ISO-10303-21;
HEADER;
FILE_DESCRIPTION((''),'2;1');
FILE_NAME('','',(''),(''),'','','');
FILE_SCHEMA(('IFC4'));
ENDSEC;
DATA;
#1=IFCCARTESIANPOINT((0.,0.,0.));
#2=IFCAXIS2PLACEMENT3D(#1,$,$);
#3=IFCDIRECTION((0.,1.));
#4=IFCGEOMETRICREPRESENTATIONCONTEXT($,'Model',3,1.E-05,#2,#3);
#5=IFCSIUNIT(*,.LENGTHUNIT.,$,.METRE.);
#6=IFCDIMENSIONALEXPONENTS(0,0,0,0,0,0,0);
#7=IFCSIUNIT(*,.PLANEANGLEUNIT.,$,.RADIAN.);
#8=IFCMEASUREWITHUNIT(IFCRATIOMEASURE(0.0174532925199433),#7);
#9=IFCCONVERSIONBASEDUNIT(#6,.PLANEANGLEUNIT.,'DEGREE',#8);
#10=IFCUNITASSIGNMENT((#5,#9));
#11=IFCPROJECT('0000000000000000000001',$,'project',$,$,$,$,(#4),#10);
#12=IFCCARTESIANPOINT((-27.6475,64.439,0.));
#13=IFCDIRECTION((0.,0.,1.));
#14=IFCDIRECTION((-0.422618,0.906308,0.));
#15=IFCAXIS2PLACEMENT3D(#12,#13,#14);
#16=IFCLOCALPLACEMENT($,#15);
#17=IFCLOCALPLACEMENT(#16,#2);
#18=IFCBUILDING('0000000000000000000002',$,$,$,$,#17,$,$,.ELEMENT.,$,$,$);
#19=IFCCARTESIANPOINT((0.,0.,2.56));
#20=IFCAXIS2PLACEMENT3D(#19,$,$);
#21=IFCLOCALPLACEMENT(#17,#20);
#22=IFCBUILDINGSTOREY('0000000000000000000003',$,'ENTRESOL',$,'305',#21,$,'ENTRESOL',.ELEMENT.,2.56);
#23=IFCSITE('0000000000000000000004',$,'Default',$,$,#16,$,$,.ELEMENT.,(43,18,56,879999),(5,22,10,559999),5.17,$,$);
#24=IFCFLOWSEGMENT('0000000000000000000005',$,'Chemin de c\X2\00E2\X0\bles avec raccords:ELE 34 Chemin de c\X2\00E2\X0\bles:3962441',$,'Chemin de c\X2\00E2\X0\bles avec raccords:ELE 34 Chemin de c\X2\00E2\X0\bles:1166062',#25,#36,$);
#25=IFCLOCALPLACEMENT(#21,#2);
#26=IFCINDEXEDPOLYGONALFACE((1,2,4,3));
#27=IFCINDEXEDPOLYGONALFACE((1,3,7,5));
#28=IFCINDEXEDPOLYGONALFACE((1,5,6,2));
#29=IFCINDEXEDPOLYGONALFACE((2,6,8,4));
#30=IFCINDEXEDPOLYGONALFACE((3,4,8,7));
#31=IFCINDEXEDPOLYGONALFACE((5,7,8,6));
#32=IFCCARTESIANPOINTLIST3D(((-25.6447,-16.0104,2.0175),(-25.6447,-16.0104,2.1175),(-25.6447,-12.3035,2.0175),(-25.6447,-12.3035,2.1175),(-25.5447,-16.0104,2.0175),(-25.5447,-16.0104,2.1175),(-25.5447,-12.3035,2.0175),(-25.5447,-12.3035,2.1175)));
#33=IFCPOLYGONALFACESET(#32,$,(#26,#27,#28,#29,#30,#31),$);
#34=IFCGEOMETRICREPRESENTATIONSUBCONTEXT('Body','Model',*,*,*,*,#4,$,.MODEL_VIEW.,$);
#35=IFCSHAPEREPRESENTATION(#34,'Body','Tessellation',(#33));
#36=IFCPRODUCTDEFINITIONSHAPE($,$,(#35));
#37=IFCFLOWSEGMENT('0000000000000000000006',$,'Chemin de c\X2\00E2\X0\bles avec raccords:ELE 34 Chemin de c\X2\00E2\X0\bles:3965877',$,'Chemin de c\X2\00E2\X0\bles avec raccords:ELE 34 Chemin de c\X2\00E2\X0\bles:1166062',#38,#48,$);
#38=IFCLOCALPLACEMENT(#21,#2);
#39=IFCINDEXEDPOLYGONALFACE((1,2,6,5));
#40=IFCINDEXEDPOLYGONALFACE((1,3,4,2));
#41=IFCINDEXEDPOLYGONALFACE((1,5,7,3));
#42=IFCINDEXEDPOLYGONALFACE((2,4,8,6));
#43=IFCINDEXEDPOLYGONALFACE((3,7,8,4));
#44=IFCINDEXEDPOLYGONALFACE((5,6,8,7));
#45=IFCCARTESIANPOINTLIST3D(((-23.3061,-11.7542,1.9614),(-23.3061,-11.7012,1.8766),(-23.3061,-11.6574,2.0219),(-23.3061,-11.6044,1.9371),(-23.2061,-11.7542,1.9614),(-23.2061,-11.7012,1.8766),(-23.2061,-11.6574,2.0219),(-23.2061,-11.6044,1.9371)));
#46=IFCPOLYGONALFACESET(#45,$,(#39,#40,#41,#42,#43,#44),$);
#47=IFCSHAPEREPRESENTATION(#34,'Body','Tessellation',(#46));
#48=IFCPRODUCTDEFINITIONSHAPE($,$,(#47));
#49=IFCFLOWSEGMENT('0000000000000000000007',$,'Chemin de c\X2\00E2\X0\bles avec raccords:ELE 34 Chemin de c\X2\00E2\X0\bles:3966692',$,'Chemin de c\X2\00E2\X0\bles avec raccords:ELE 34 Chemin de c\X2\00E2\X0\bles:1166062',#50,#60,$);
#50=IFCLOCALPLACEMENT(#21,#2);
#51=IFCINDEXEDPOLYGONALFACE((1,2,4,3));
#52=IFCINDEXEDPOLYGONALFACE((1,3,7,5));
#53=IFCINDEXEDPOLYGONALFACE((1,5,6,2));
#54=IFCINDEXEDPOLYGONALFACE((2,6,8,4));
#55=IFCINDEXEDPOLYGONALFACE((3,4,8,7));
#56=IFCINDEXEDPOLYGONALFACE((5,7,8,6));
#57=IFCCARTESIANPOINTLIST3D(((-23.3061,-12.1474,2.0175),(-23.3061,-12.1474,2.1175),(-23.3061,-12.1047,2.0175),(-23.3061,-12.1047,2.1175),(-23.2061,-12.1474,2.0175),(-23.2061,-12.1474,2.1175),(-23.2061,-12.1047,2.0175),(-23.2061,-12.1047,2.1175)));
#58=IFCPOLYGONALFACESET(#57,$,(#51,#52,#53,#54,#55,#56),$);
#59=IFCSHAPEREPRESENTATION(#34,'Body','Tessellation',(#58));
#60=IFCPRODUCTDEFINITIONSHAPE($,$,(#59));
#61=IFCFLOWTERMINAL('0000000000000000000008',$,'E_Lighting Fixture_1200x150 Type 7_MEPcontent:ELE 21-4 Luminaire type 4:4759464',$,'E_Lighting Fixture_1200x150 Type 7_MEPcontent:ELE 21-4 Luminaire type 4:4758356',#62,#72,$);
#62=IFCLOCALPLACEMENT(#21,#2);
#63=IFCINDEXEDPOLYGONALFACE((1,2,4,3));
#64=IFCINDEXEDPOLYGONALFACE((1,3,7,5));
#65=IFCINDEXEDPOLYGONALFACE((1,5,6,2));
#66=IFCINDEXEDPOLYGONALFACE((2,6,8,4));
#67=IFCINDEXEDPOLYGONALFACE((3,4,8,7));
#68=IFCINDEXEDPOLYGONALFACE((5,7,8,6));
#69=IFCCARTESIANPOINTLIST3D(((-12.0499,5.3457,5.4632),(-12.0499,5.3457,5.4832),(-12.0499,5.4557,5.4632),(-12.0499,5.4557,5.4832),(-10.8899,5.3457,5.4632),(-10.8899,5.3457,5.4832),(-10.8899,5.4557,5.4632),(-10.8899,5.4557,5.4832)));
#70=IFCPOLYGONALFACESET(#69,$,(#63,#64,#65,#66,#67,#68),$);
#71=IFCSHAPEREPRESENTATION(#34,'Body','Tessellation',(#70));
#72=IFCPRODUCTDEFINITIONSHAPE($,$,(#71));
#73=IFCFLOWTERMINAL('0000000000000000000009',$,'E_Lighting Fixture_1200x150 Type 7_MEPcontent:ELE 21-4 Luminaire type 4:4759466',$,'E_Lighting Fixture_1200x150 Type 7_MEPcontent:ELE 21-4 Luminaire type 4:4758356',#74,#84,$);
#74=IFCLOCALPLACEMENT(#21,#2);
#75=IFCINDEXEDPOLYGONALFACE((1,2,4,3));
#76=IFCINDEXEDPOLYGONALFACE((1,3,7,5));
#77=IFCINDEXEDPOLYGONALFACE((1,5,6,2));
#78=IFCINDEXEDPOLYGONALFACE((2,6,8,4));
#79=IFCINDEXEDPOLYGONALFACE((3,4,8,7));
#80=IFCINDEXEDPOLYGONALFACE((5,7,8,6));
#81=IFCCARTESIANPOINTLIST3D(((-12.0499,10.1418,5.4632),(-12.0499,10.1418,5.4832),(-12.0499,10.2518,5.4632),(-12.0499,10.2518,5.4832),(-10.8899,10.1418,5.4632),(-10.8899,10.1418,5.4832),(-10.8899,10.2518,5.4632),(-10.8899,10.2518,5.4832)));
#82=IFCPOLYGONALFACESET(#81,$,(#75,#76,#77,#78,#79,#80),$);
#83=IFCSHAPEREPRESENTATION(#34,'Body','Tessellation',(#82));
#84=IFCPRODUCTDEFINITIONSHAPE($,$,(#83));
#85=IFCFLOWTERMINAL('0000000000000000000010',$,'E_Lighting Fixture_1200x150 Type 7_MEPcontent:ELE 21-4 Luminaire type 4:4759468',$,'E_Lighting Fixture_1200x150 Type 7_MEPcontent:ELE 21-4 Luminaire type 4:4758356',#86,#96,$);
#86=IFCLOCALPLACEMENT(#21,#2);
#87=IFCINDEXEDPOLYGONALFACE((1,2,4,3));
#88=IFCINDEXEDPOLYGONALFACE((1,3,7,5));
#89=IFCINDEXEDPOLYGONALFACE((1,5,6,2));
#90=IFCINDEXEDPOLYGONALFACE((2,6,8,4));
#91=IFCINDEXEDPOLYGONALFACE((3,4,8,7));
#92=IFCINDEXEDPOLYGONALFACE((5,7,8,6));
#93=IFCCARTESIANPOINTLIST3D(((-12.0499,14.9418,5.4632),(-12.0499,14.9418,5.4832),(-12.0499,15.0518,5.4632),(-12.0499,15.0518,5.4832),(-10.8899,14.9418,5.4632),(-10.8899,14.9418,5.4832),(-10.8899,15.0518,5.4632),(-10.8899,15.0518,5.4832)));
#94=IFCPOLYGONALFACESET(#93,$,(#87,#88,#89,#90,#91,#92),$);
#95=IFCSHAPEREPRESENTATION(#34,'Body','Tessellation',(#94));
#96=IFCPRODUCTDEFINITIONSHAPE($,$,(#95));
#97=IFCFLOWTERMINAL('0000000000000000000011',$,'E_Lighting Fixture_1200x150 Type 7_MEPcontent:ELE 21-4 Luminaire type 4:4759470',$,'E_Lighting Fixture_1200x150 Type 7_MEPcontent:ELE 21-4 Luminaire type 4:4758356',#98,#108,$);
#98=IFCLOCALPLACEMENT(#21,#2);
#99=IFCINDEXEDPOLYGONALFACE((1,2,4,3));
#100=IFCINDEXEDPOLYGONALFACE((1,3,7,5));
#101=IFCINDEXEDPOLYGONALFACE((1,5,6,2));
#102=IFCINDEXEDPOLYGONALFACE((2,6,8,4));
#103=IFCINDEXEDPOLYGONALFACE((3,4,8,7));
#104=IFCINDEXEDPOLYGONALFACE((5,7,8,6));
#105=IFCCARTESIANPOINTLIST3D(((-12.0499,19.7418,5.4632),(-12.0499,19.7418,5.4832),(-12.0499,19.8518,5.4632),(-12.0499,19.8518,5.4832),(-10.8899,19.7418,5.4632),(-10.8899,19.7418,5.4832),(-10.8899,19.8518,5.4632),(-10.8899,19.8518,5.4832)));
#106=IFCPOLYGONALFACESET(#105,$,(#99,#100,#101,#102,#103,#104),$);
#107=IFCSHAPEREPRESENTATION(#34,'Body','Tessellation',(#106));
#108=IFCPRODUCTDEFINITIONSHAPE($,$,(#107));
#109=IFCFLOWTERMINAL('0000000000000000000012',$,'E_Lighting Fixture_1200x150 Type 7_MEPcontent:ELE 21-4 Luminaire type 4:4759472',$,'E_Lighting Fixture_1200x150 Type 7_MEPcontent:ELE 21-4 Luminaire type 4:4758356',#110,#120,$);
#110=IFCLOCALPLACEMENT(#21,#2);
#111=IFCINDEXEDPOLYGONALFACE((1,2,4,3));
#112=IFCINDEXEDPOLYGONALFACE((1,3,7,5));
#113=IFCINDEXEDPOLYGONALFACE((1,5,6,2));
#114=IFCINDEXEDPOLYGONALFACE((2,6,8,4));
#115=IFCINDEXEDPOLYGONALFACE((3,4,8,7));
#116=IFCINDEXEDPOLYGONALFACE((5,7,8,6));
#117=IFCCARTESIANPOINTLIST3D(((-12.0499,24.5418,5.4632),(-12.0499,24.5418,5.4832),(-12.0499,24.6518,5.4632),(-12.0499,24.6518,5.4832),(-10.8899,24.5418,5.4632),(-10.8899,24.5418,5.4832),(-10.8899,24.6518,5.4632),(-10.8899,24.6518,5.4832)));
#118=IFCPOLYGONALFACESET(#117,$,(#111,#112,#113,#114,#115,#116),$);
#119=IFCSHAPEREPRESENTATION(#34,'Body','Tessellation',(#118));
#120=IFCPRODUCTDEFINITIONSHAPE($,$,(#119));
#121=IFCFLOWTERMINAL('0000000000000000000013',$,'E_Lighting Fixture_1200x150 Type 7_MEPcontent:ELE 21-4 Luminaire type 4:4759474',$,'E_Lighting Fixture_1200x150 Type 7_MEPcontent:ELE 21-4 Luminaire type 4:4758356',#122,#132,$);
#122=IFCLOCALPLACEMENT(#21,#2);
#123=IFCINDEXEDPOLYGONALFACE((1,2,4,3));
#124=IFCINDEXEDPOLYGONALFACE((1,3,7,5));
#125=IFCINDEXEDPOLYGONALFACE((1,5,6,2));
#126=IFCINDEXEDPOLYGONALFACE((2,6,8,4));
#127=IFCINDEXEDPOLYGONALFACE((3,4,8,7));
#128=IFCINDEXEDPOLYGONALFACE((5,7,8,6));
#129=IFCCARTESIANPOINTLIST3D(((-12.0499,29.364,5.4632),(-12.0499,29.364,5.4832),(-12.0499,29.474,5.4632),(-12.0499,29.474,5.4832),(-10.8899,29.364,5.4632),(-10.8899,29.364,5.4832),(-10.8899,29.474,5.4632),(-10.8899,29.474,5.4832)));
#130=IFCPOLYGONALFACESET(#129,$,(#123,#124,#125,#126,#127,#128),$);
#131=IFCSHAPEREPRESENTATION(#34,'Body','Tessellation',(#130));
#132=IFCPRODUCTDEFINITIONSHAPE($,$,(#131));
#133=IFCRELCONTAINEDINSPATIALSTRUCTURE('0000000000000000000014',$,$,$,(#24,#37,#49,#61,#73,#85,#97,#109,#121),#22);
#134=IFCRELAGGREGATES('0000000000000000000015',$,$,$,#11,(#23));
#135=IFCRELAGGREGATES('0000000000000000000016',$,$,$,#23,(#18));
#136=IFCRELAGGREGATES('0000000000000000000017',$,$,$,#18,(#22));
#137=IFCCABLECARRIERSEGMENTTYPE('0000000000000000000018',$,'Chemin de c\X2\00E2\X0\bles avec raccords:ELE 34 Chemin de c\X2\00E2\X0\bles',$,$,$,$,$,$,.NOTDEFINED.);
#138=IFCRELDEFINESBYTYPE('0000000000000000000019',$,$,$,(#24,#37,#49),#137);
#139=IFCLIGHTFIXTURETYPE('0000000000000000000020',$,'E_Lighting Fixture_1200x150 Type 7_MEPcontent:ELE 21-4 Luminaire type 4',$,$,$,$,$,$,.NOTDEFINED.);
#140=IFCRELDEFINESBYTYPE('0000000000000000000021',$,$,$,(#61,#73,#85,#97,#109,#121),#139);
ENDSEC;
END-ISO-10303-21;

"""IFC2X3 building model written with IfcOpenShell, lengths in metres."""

from ifc_helpers import new_model, entity, si_unit, converted_unit, direction, frame, frame_2d, origin, origin_2d_with_axis, place, context, subcontext, project, spatial, rectangle, extrude, source, transform, mapped, type_object, type_shapes, element, save


model = new_model("IFC2X3")

# Units and contexts
model_context = context("Model", 3, precision=1e-05, world=origin(), true_north=direction((0.0, 1.0)))
body_context = subcontext(model_context, "Body", "Model", "MODEL_VIEW")
ifc_project = project(units=[si_unit("LENGTHUNIT", "METRE"), converted_unit("PLANEANGLEUNIT", "DEGREE", entity("IfcRatioMeasure", 0.0174532925199433), si_unit("PLANEANGLEUNIT", "RADIAN"), dimensions=[0, 0, 0, 0, 0, 0, 0])], contexts=[model_context])

# Site, building, storey
site_placement = place(None, frame((-27.6475, 64.439, 0.0), z_axis=(0.0, 0.0, 1.0), x_axis=(-0.422618, 0.906308, 0.0)))
site = spatial("IfcSite", under=ifc_project, at=site_placement, Name="Default", CompositionType="ELEMENT", RefLatitude=(43, 18, 56, 879999), RefLongitude=(5, 22, 10, 559999), RefElevation=5.17)
building_placement = place(site_placement, origin())
building = spatial("IfcBuilding", under=site, at=building_placement, CompositionType="ELEMENT")
storey_placement = place(building_placement, frame((0.0, 0.0, 2.56)))
storey = spatial("IfcBuildingStorey", under=building, at=storey_placement, Name="ENTRESOL", ObjectType="305", LongName="ENTRESOL", CompositionType="ELEMENT", Elevation=2.56)

# Flow segments
cable_carrier_segment_type = type_object("IfcCableCarrierSegmentType", Name="Chemin de câbles avec raccords:ELE 34 Chemin de câbles", PredefinedType="NOTDEFINED")
flow_segment_1_placement = place(storey_placement, origin())
element("IfcFlowSegment", 1, at=flow_segment_1_placement, inside=storey, type_object=cable_carrier_segment_type, Name="Chemin de câbles avec raccords:ELE 34 Chemin de câbles:3962441", ObjectType="Chemin de câbles avec raccords:ELE 34 Chemin de câbles:1166062", context=body_context, shape_type="SweptSolid", body=[
    extrude(rectangle(XDim=3.7069, YDim=0.1, at=frame_2d((0.0, 0.0), x_axis=(1.0, 0.0))), frame((-25.5947, -14.1569, 2.0175), z_axis=(0.0, 0.0, 1.0), x_axis=(0.0, -1.0, 0.0)), (0.0, 0.0, 1.0), 0.1),
])
flow_segment_2_placement = place(storey_placement, origin())
element("IfcFlowSegment", 2, at=flow_segment_2_placement, inside=storey, type_object=cable_carrier_segment_type, Name="Chemin de câbles avec raccords:ELE 34 Chemin de câbles:3965877", ObjectType="Chemin de câbles avec raccords:ELE 34 Chemin de câbles:1166062", context=body_context, shape_type="SweptSolid", body=[
    extrude(rectangle(XDim=0.1, YDim=0.1141, at=frame_2d((0.0, 0.0), x_axis=(0.0, 1.0))), frame((-23.3061, -11.6793, 1.9493), z_axis=(1.0, 0.0, -0.000185), x_axis=(0.000098, 0.84814, 0.529772)), (0.0, 0.0, 1.0), 0.1),
])
flow_segment_3_placement = place(storey_placement, origin())
element("IfcFlowSegment", 3, at=flow_segment_3_placement, inside=storey, type_object=cable_carrier_segment_type, Name="Chemin de câbles avec raccords:ELE 34 Chemin de câbles:3966692", ObjectType="Chemin de câbles avec raccords:ELE 34 Chemin de câbles:1166062", context=body_context, shape_type="SweptSolid", body=[
    extrude(rectangle(XDim=0.0427, YDim=0.1, at=origin_2d_with_axis()), frame((-23.2561, -12.1261, 2.0175), z_axis=(0.0, 0.0, 1.0), x_axis=(0.0, 1.0, 0.0)), (0.0, 0.0, 1.0), 0.1),
])

# Flow terminals
light_fixture_type = type_object("IfcLightFixtureType", Name="E_Lighting Fixture_1200x150 Type 7_MEPcontent:ELE 21-4 Luminaire type 4", PredefinedType="NOTDEFINED")
shared_shape = source(origin(), body_context, "Body", "SweptSolid", [
    extrude(rectangle(XDim=0.11, YDim=1.16, at=origin_2d_with_axis()), frame((0.0, 0.0, 0.0), z_axis=(0.0, 0.0, 1.0), x_axis=(0.0, -1.0, 0.0)), (0.0, 0.0, 1.0), 0.02),
])
type_shapes(light_fixture_type, [shared_shape])
for number, where, name in (
    (4, (-11.4699, 5.4007, 5.4632), "E_Lighting Fixture_1200x150 Type 7_MEPcontent:ELE 21-4 Luminaire type 4:4759464"),
    (5, (-11.4699, 10.1968, 5.4632), "E_Lighting Fixture_1200x150 Type 7_MEPcontent:ELE 21-4 Luminaire type 4:4759466"),
    (6, (-11.4699, 14.9968, 5.4632), "E_Lighting Fixture_1200x150 Type 7_MEPcontent:ELE 21-4 Luminaire type 4:4759468"),
    (7, (-11.4699, 19.7968, 5.4632), "E_Lighting Fixture_1200x150 Type 7_MEPcontent:ELE 21-4 Luminaire type 4:4759470"),
    (8, (-11.4699, 24.5968, 5.4632), "E_Lighting Fixture_1200x150 Type 7_MEPcontent:ELE 21-4 Luminaire type 4:4759472"),
    (9, (-11.4699, 29.419, 5.4632), "E_Lighting Fixture_1200x150 Type 7_MEPcontent:ELE 21-4 Luminaire type 4:4759474"),
):
    element("IfcFlowTerminal", number, at=place(storey_placement, frame(where)), inside=storey, type_object=light_fixture_type, Name=name, ObjectType="E_Lighting Fixture_1200x150 Type 7_MEPcontent:ELE 21-4 Luminaire type 4:4758356", context=body_context, shape_type="MappedRepresentation", body=[
        mapped(shared_shape, transform((0.0, 0.0, 0.0), scale=1.0)),
    ])

save(model, "model.ifc")
